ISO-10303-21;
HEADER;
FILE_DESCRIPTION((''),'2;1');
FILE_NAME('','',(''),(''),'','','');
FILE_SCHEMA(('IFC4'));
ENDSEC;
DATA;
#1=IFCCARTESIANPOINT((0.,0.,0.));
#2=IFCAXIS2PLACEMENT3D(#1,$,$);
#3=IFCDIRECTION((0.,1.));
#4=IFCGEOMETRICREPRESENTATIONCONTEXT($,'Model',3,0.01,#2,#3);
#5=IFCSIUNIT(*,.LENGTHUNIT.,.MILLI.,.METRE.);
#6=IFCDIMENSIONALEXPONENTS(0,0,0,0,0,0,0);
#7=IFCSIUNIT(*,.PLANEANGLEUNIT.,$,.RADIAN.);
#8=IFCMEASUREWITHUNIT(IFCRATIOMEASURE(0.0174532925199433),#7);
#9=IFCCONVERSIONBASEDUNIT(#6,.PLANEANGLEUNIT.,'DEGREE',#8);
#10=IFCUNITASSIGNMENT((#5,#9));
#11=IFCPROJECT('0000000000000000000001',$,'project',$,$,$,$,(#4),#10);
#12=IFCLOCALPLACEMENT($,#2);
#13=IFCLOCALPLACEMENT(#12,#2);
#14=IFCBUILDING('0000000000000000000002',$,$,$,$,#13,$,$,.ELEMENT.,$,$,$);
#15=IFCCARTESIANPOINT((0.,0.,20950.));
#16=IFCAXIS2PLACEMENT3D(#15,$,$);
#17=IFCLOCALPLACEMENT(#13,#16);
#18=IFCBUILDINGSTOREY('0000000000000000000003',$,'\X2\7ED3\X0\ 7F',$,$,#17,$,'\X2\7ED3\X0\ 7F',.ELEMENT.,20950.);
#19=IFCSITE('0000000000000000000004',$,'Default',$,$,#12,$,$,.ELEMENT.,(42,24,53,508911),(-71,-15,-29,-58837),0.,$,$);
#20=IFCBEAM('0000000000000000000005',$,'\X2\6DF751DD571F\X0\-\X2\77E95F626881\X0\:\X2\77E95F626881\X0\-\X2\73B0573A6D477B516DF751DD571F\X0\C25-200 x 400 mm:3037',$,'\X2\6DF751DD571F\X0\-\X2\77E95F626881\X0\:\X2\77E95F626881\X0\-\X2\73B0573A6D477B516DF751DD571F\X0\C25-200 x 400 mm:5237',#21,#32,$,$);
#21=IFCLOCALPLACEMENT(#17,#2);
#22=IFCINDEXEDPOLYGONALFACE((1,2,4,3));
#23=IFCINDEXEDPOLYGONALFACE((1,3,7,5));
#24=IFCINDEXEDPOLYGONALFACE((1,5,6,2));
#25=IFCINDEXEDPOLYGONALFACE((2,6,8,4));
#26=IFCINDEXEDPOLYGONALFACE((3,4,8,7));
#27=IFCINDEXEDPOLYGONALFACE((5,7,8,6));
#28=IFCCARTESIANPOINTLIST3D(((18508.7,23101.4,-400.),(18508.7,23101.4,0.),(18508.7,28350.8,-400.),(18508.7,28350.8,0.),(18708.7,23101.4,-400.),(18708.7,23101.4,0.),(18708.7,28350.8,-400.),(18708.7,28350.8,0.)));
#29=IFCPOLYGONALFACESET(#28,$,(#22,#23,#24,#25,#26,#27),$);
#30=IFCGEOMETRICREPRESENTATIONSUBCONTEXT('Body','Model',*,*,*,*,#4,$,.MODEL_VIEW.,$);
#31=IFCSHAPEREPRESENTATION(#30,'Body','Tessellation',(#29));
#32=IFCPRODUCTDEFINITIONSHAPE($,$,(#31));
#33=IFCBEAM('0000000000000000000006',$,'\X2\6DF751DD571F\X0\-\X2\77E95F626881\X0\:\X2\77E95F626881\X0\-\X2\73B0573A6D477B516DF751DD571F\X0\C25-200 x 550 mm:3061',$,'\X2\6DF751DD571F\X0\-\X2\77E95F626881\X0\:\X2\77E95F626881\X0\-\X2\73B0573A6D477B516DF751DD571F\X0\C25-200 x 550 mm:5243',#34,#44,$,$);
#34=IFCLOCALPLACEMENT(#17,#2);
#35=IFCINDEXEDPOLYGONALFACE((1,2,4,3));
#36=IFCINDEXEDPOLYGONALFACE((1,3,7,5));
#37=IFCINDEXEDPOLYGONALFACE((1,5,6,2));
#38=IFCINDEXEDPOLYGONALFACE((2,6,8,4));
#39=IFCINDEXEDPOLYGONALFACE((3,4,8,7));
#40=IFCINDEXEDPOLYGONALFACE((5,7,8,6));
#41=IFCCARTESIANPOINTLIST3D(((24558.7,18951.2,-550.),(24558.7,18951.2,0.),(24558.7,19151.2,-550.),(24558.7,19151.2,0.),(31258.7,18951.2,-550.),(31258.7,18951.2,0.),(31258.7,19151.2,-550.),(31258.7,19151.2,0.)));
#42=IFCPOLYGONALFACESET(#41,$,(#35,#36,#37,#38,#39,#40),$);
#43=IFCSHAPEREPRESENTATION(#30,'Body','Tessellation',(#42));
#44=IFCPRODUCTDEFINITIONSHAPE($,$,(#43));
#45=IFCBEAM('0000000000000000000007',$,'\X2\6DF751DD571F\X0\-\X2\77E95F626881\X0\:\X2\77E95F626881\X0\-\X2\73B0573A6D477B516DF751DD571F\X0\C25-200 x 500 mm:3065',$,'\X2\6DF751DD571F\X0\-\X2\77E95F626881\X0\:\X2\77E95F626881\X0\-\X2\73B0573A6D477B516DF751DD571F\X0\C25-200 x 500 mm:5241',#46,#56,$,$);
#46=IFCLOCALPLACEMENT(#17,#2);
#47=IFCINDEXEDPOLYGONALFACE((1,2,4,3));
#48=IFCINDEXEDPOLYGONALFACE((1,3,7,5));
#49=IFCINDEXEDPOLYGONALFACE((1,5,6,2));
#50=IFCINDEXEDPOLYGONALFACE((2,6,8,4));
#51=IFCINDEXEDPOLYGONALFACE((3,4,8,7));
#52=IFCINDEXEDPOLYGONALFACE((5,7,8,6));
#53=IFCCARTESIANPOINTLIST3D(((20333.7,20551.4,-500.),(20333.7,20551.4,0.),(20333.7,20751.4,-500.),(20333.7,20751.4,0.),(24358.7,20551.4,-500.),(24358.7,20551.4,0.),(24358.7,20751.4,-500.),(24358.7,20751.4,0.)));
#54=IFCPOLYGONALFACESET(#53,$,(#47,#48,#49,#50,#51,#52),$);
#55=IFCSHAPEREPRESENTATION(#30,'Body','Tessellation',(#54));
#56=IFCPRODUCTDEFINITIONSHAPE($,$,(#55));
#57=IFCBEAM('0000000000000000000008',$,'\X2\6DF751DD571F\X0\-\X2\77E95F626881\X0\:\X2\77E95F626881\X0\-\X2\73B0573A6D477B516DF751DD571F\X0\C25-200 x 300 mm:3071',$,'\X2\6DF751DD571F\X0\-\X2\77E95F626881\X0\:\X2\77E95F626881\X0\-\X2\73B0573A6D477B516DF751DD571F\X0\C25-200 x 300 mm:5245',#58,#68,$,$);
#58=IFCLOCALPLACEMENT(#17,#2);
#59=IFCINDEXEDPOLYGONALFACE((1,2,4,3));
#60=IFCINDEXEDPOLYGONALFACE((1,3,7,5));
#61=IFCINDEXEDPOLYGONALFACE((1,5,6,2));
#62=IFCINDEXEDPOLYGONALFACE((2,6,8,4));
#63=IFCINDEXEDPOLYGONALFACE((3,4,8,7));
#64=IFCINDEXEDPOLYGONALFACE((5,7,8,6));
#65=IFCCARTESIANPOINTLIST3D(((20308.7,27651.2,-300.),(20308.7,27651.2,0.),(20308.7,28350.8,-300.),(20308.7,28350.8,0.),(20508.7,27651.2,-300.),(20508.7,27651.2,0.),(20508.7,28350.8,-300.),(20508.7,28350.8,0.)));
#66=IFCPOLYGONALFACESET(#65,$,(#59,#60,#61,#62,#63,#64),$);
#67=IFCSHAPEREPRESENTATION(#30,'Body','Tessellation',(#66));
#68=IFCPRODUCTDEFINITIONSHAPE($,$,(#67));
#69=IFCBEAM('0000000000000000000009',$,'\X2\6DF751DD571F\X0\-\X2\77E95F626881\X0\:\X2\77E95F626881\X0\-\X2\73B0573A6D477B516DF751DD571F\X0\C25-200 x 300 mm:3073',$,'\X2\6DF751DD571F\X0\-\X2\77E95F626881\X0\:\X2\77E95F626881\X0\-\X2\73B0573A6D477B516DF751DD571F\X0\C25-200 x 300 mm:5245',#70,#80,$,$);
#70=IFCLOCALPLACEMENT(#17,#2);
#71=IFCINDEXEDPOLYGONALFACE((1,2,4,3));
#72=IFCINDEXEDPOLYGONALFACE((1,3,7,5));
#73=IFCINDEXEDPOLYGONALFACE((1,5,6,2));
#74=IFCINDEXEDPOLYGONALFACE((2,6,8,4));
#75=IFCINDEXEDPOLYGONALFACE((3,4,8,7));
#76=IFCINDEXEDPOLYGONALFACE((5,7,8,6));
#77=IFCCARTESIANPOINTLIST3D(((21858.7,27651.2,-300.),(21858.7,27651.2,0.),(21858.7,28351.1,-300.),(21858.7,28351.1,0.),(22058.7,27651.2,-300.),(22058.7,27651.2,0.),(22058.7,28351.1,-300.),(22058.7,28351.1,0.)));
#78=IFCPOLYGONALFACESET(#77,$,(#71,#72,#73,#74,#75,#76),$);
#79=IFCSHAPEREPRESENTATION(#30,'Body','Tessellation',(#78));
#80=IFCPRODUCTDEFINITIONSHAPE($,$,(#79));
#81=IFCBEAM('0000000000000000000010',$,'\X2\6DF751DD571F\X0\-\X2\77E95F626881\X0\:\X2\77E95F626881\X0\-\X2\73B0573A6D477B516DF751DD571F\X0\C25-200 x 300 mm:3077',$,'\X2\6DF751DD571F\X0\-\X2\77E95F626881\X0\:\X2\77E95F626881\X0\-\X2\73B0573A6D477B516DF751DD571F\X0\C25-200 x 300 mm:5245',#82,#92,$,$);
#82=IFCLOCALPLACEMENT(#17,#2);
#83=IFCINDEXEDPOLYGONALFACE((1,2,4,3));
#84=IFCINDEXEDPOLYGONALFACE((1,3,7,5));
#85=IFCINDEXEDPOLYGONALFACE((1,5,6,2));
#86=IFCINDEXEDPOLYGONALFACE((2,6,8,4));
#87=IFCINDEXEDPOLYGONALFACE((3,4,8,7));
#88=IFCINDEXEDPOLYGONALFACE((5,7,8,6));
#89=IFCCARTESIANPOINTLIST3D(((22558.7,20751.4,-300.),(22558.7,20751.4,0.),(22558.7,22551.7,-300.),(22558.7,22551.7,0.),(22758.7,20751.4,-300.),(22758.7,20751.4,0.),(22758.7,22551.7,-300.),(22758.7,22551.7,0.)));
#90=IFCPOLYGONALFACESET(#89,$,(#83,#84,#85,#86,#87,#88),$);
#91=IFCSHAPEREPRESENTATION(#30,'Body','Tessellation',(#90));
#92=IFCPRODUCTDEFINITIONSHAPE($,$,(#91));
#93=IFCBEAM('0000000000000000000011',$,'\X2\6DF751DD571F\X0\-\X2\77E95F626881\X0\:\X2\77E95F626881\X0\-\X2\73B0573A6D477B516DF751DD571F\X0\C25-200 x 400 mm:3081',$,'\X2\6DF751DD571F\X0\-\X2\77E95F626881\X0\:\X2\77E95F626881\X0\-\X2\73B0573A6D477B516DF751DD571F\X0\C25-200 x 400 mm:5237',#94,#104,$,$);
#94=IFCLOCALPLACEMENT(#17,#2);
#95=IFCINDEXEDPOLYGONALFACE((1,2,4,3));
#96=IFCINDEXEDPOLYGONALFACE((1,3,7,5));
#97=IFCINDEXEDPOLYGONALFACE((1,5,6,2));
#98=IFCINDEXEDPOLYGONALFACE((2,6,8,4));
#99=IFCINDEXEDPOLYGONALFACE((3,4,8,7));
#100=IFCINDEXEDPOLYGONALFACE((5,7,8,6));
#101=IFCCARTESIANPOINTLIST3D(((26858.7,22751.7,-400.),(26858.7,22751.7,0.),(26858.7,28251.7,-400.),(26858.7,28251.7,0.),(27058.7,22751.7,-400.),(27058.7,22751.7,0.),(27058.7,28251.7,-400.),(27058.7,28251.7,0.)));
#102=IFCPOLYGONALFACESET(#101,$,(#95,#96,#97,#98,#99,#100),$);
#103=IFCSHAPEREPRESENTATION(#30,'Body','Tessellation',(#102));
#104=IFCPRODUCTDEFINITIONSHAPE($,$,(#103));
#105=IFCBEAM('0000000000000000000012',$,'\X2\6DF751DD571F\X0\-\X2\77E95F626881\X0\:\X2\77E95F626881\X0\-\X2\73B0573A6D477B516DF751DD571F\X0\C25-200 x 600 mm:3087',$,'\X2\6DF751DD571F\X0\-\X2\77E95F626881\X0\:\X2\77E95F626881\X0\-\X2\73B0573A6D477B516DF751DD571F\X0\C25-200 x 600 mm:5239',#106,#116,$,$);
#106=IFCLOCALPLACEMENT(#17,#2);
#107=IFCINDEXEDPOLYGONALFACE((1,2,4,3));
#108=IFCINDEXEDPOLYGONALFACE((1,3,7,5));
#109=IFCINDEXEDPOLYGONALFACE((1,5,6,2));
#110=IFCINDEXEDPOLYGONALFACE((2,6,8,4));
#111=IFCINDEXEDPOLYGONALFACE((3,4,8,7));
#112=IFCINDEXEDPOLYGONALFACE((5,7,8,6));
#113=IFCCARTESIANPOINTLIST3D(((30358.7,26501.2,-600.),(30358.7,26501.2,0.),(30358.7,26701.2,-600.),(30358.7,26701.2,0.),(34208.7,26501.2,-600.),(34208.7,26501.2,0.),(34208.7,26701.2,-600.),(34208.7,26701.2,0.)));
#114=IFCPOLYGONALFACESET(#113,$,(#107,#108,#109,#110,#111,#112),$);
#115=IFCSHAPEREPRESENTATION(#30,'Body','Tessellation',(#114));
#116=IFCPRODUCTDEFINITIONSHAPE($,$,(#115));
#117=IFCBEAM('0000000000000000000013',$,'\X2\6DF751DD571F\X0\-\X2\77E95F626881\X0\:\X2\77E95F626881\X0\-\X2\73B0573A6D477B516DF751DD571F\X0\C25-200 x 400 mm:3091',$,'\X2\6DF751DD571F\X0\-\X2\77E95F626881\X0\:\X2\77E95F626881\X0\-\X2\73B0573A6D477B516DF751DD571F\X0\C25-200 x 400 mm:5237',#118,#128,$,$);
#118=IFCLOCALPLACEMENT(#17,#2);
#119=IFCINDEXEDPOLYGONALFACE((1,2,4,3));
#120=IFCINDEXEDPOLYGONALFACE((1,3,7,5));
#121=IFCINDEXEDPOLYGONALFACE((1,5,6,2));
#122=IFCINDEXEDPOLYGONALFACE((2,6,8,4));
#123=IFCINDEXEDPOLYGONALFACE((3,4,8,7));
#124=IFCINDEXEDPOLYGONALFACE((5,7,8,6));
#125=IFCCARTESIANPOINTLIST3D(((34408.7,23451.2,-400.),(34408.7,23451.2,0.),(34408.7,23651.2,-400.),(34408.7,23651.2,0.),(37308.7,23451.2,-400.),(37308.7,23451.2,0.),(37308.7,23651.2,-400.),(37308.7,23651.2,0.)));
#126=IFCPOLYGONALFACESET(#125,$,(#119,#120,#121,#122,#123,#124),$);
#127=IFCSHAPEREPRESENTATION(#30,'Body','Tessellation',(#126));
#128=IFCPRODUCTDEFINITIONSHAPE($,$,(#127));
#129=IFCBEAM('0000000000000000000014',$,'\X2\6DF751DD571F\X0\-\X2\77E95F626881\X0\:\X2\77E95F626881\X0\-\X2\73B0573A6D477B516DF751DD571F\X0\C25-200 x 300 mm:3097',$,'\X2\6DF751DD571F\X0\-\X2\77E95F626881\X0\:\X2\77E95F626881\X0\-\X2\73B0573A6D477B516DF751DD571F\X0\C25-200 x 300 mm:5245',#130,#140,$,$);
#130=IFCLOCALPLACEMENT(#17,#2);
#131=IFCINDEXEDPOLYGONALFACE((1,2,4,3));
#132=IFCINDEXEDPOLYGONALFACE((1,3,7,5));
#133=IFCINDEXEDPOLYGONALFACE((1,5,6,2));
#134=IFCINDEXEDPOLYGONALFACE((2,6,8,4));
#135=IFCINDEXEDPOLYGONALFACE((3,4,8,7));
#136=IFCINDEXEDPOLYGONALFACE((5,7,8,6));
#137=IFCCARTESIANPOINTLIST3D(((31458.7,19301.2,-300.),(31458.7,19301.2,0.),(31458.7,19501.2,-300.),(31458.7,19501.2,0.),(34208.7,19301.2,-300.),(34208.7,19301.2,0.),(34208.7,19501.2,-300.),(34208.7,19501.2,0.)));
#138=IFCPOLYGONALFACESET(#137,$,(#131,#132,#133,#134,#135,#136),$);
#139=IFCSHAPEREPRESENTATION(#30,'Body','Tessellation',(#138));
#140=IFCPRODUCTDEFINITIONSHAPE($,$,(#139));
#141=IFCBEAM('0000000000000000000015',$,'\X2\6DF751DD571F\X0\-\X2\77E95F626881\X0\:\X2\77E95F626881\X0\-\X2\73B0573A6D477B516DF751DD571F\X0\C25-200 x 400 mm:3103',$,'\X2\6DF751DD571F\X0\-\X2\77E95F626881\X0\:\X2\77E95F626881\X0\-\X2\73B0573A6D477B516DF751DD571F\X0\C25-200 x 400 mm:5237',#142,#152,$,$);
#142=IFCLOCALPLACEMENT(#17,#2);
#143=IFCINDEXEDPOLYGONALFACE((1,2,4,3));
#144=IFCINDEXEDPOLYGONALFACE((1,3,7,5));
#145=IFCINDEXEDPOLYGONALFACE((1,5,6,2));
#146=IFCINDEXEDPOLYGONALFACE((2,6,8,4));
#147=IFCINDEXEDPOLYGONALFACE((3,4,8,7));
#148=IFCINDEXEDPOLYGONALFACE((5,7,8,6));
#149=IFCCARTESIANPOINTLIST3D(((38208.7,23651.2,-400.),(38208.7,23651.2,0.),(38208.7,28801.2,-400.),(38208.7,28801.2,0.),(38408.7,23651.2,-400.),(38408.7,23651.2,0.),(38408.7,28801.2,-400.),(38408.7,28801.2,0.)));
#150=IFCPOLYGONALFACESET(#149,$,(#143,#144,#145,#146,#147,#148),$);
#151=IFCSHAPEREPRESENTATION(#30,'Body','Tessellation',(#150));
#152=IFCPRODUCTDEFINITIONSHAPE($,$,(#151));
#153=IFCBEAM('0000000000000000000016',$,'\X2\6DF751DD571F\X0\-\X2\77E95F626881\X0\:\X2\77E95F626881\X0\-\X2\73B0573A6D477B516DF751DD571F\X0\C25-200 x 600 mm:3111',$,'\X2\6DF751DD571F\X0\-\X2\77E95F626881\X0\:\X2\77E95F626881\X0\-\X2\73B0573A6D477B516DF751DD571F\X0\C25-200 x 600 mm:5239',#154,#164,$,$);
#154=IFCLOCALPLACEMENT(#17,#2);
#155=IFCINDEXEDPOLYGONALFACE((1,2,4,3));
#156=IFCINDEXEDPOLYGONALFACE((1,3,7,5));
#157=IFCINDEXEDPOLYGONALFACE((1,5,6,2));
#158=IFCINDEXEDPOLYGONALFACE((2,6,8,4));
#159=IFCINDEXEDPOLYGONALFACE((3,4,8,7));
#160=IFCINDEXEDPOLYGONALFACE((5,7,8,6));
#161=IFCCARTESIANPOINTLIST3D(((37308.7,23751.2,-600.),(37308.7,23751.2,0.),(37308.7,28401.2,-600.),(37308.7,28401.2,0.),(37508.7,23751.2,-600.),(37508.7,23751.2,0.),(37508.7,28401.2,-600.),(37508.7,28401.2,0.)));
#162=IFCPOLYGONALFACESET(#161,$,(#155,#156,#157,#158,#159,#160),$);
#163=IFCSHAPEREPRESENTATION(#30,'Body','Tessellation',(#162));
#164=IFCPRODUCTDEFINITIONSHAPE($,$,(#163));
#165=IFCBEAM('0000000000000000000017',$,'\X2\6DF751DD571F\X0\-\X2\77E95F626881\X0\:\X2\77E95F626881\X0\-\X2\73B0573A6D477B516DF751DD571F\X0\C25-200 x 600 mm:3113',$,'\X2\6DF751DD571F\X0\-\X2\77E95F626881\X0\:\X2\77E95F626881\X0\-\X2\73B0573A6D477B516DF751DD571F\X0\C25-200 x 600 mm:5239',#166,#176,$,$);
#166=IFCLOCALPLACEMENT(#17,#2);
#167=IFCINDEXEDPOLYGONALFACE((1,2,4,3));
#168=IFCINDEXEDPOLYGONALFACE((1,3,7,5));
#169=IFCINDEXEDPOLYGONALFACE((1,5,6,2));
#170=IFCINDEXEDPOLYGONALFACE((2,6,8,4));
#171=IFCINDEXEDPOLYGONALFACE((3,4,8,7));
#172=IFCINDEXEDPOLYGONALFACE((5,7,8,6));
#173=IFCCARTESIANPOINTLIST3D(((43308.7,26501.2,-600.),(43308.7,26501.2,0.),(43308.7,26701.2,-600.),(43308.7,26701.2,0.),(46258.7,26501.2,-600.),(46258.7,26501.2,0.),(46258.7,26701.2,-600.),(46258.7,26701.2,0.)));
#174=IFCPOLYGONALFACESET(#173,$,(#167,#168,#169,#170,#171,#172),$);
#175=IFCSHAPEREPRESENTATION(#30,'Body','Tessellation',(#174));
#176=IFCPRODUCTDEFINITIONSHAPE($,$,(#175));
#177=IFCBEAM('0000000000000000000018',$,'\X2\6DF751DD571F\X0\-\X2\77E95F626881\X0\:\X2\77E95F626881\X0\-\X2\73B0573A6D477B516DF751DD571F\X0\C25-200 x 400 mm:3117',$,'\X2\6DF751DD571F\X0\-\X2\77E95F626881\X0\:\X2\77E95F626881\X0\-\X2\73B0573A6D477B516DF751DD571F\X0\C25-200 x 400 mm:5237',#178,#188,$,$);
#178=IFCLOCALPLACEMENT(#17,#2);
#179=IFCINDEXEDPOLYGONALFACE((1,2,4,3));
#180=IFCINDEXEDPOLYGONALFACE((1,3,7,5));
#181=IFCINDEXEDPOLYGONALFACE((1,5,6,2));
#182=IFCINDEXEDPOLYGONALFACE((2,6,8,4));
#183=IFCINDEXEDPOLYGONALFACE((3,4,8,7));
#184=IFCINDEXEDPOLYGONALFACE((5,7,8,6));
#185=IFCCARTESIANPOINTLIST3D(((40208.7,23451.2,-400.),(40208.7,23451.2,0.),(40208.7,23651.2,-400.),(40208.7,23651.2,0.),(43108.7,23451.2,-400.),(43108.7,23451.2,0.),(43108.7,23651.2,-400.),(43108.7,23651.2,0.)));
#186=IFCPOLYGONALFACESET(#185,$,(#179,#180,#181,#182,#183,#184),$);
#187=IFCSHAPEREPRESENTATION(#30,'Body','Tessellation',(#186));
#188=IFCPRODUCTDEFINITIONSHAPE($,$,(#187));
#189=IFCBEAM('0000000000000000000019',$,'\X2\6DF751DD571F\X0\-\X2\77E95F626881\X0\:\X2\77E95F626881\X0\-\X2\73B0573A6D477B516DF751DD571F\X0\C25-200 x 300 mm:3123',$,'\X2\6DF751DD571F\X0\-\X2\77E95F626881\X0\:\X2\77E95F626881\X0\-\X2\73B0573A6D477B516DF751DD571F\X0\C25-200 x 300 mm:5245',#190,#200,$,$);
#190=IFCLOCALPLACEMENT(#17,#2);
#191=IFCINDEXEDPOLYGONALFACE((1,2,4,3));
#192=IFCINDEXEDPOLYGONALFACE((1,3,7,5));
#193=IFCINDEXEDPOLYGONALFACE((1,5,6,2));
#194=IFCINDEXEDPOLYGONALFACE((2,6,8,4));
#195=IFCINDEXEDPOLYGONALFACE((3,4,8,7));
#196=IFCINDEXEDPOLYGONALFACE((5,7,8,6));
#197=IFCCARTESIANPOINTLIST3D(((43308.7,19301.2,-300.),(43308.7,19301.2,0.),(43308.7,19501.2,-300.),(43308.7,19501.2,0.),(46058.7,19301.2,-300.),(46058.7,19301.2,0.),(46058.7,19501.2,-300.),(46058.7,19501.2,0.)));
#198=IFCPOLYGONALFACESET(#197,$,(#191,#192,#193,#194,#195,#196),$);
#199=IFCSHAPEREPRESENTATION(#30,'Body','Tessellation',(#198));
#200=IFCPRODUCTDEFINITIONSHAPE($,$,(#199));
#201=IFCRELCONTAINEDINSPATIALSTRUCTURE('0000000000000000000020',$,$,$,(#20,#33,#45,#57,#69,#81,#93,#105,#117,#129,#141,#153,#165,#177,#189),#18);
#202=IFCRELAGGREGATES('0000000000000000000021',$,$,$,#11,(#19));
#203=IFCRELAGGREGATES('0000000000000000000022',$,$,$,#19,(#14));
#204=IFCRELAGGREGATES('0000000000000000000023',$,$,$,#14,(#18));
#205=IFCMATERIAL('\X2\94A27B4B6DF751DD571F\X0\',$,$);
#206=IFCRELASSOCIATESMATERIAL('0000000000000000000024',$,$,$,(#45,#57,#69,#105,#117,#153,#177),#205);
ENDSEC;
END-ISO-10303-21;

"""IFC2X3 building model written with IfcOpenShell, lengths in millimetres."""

from ifc_helpers import new_model, entity, si_unit, converted_unit, direction, frame, frame_2d, origin, origin_2d_with_axis, place, context, subcontext, project, spatial, rectangle, extrude, material, element, save


model = new_model("IFC2X3")

# Units and contexts
model_context = context("Model", 3, precision=0.01, world=origin(), true_north=direction((0.0, 1.0)))
body_context = subcontext(model_context, "Body", "Model", "MODEL_VIEW")
ifc_project = project(units=[si_unit("LENGTHUNIT", "METRE", prefix="MILLI"), converted_unit("PLANEANGLEUNIT", "DEGREE", entity("IfcRatioMeasure", 0.0174532925199433), si_unit("PLANEANGLEUNIT", "RADIAN"), dimensions=[0, 0, 0, 0, 0, 0, 0])], contexts=[model_context])

# Site, building, storey
site_placement = place(None, origin())
site = spatial("IfcSite", under=ifc_project, at=site_placement, Name="Default", CompositionType="ELEMENT", RefLatitude=(42, 24, 53, 508911), RefLongitude=(-71, -15, -29, -58837), RefElevation=0.0)
building_placement = place(site_placement, origin())
building = spatial("IfcBuilding", under=site, at=building_placement, CompositionType="ELEMENT")
storey_placement = place(building_placement, frame((0.0, 0.0, 20950.0)))
storey = spatial("IfcBuildingStorey", under=building, at=storey_placement, Name="结 7F", LongName="结 7F", CompositionType="ELEMENT", Elevation=20950.0)

# Beams
beam_1_placement = place(storey_placement, frame((18608.7, 23001.4, 0.0), z_axis=(0.0, 0.0, 1.0), x_axis=(0.0, 1.0, 0.0)))
element("IfcBeam", 1, at=beam_1_placement, inside=storey, Name="混凝土-矩形梁:矩形梁-现场浇筑混凝土C25-200 x 400 mm:3037", ObjectType="混凝土-矩形梁:矩形梁-现场浇筑混凝土C25-200 x 400 mm:5237", context=body_context, shape_type="SweptSolid", body=[
    extrude(rectangle(XDim=400.0, YDim=200.0, at=frame_2d((0.0, 0.0), x_axis=(1.0, 0.0))), frame((100.0, 0.0, -200.0), z_axis=(1.0, 0.0, 0.0), x_axis=(0.0, 0.0, -1.0)), (0.0, 0.0, 1.0), 5249.4),
])
ifc_material = material(Name="钢筋混凝土")
beam_2_placement = place(storey_placement, frame((31358.7, 19051.2, 0.0), z_axis=(0.0, 0.0, 1.0), x_axis=(-1.0, 0.0, 0.0)))
element("IfcBeam", 2, at=beam_2_placement, inside=storey, Name="混凝土-矩形梁:矩形梁-现场浇筑混凝土C25-200 x 550 mm:3061", ObjectType="混凝土-矩形梁:矩形梁-现场浇筑混凝土C25-200 x 550 mm:5243", context=body_context, shape_type="SweptSolid", body=[
    extrude(rectangle(XDim=550.0, YDim=200.0, at=frame_2d((0.0, 0.0), x_axis=(1.0, 0.0))), frame((100.0, 0.0, -275.0), z_axis=(1.0, 0.0, 0.0), x_axis=(0.0, 0.0, -1.0)), (0.0, 0.0, 1.0), 6700.0),
])
beam_3_placement = place(storey_placement, frame((24458.7, 20651.4, 0.0), z_axis=(0.0, 0.0, 1.0), x_axis=(-1.0, 0.0, 0.0)))
element("IfcBeam", 3, at=beam_3_placement, inside=storey, material=ifc_material, Name="混凝土-矩形梁:矩形梁-现场浇筑混凝土C25-200 x 500 mm:3065", ObjectType="混凝土-矩形梁:矩形梁-现场浇筑混凝土C25-200 x 500 mm:5241", context=body_context, shape_type="SweptSolid", body=[
    extrude(rectangle(XDim=500.0, YDim=200.0, at=frame_2d((0.0, 0.0), x_axis=(1.0, 0.0))), frame((100.0, 0.0, -250.0), z_axis=(1.0, 0.0, 0.0), x_axis=(0.0, 0.0, -1.0)), (0.0, 0.0, 1.0), 4025.0),
])
beam_4_placement = place(storey_placement, frame((20408.7, 27551.2, 0.0), z_axis=(0.0, 0.0, 1.0), x_axis=(0.0, 1.0, 0.0)))
element("IfcBeam", 4, at=beam_4_placement, inside=storey, material=ifc_material, Name="混凝土-矩形梁:矩形梁-现场浇筑混凝土C25-200 x 300 mm:3071", ObjectType="混凝土-矩形梁:矩形梁-现场浇筑混凝土C25-200 x 300 mm:5245", context=body_context, shape_type="SweptSolid", body=[
    extrude(rectangle(XDim=300.0, YDim=200.0, at=frame_2d((0.0, 0.0), x_axis=(1.0, 0.0))), frame((100.0, 0.0, -150.0), z_axis=(1.0, 0.0, 0.0), x_axis=(0.0, 0.0, -1.0)), (0.0, 0.0, 1.0), 699.6),
])
beam_5_placement = place(storey_placement, frame((21958.7, 27551.2, 0.0), z_axis=(0.0, 0.0, 1.0), x_axis=(0.0, 1.0, 0.0)))
element("IfcBeam", 5, at=beam_5_placement, inside=storey, material=ifc_material, Name="混凝土-矩形梁:矩形梁-现场浇筑混凝土C25-200 x 300 mm:3073", ObjectType="混凝土-矩形梁:矩形梁-现场浇筑混凝土C25-200 x 300 mm:5245", context=body_context, shape_type="SweptSolid", body=[
    extrude(rectangle(XDim=300.0, YDim=200.0, at=frame_2d((0.0, 0.0), x_axis=(1.0, 0.0))), frame((100.0, 0.0, -150.0), z_axis=(1.0, 0.0, 0.0), x_axis=(0.0, 0.0, -1.0)), (0.0, 0.0, 1.0), 699.9),
])
beam_6_placement = place(storey_placement, frame((22658.7, 20651.4, 0.0), z_axis=(0.0, 0.0, 1.0), x_axis=(0.0, 1.0, 0.0)))
element("IfcBeam", 6, at=beam_6_placement, inside=storey, Name="混凝土-矩形梁:矩形梁-现场浇筑混凝土C25-200 x 300 mm:3077", ObjectType="混凝土-矩形梁:矩形梁-现场浇筑混凝土C25-200 x 300 mm:5245", context=body_context, shape_type="SweptSolid", body=[
    extrude(rectangle(XDim=300.0, YDim=200.0, at=origin_2d_with_axis()), frame((100.0, 0.0, -150.0), z_axis=(1.0, 0.0, 0.0), x_axis=(0.0, 0.0, -1.0)), (0.0, 0.0, 1.0), 1800.3),
])
beam_7_placement = place(storey_placement, frame((26958.7, 22651.7, 0.0), z_axis=(0.0, 0.0, 1.0), x_axis=(0.0, 1.0, 0.0)))
element("IfcBeam", 7, at=beam_7_placement, inside=storey, Name="混凝土-矩形梁:矩形梁-现场浇筑混凝土C25-200 x 400 mm:3081", ObjectType="混凝土-矩形梁:矩形梁-现场浇筑混凝土C25-200 x 400 mm:5237", context=body_context, shape_type="SweptSolid", body=[
    extrude(rectangle(XDim=400.0, YDim=200.0, at=frame_2d((0.0, 0.0), x_axis=(1.0, 0.0))), frame((100.0, 0.0, -200.0), z_axis=(1.0, 0.0, 0.0), x_axis=(0.0, 0.0, -1.0)), (0.0, 0.0, 1.0), 5500.0),
])
beam_8_placement = place(storey_placement, frame((34308.7, 26601.2, 0.0), z_axis=(0.0, 0.0, 1.0), x_axis=(-1.0, 0.0, 0.0)))
element("IfcBeam", 8, at=beam_8_placement, inside=storey, material=ifc_material, Name="混凝土-矩形梁:矩形梁-现场浇筑混凝土C25-200 x 600 mm:3087", ObjectType="混凝土-矩形梁:矩形梁-现场浇筑混凝土C25-200 x 600 mm:5239", context=body_context, shape_type="SweptSolid", body=[
    extrude(rectangle(XDim=600.0, YDim=200.0, at=frame_2d((0.0, 0.0), x_axis=(1.0, 0.0))), frame((100.0, 0.0, -300.0), z_axis=(1.0, 0.0, 0.0), x_axis=(0.0, 0.0, -1.0)), (0.0, 0.0, 1.0), 3850.0),
])
beam_9_placement = place(storey_placement, frame((34308.7, 23551.2, 0.0)))
element("IfcBeam", 9, at=beam_9_placement, inside=storey, material=ifc_material, Name="混凝土-矩形梁:矩形梁-现场浇筑混凝土C25-200 x 400 mm:3091", ObjectType="混凝土-矩形梁:矩形梁-现场浇筑混凝土C25-200 x 400 mm:5237", context=body_context, shape_type="SweptSolid", body=[
    extrude(rectangle(XDim=400.0, YDim=200.0, at=frame_2d((0.0, 0.0), x_axis=(1.0, 0.0))), frame((100.0, 0.0, -200.0), z_axis=(1.0, 0.0, 0.0), x_axis=(0.0, 0.0, -1.0)), (0.0, 0.0, 1.0), 2900.0),
])
beam_10_placement = place(storey_placement, frame((31358.7, 19401.2, 0.0)))
element("IfcBeam", 10, at=beam_10_placement, inside=storey, Name="混凝土-矩形梁:矩形梁-现场浇筑混凝土C25-200 x 300 mm:3097", ObjectType="混凝土-矩形梁:矩形梁-现场浇筑混凝土C25-200 x 300 mm:5245", context=body_context, shape_type="SweptSolid", body=[
    extrude(rectangle(XDim=300.0, YDim=200.0, at=frame_2d((0.0, 0.0), x_axis=(1.0, 0.0))), frame((100.0, 0.0, -150.0), z_axis=(1.0, 0.0, 0.0), x_axis=(0.0, 0.0, -1.0)), (0.0, 0.0, 1.0), 2750.0),
])
beam_11_placement = place(storey_placement, frame((38308.7, 23551.2, 0.0), z_axis=(0.0, 0.0, 1.0), x_axis=(0.0, 1.0, 0.0)))
element("IfcBeam", 11, at=beam_11_placement, inside=storey, Name="混凝土-矩形梁:矩形梁-现场浇筑混凝土C25-200 x 400 mm:3103", ObjectType="混凝土-矩形梁:矩形梁-现场浇筑混凝土C25-200 x 400 mm:5237", context=body_context, shape_type="SweptSolid", body=[
    extrude(rectangle(XDim=400.0, YDim=200.0, at=frame_2d((0.0, 0.0), x_axis=(1.0, 0.0))), frame((100.0, 0.0, -200.0), z_axis=(1.0, 0.0, 0.0), x_axis=(0.0, 0.0, -1.0)), (0.0, 0.0, 1.0), 5150.0),
])
beam_12_placement = place(storey_placement, frame((37408.7, 23551.2, 0.0), z_axis=(0.0, 0.0, 1.0), x_axis=(0.0, 1.0, 0.0)))
element("IfcBeam", 12, at=beam_12_placement, inside=storey, material=ifc_material, Name="混凝土-矩形梁:矩形梁-现场浇筑混凝土C25-200 x 600 mm:3111", ObjectType="混凝土-矩形梁:矩形梁-现场浇筑混凝土C25-200 x 600 mm:5239", context=body_context, shape_type="SweptSolid", body=[
    extrude(rectangle(XDim=600.0, YDim=200.0, at=frame_2d((0.0, 0.0), x_axis=(1.0, 0.0))), frame((200.0, 0.0, -300.0), z_axis=(1.0, 0.0, 0.0), x_axis=(0.0, 0.0, -1.0)), (0.0, 0.0, 1.0), 4650.0),
])
beam_13_placement = place(storey_placement, frame((43208.7, 26601.2, 0.0)))
element("IfcBeam", 13, at=beam_13_placement, inside=storey, Name="混凝土-矩形梁:矩形梁-现场浇筑混凝土C25-200 x 600 mm:3113", ObjectType="混凝土-矩形梁:矩形梁-现场浇筑混凝土C25-200 x 600 mm:5239", context=body_context, shape_type="SweptSolid", body=[
    extrude(rectangle(XDim=600.0, YDim=200.0, at=frame_2d((0.0, 0.0), x_axis=(1.0, 0.0))), frame((100.0, 0.0, -300.0), z_axis=(1.0, 0.0, 0.0), x_axis=(0.0, 0.0, -1.0)), (0.0, 0.0, 1.0), 2950.0),
])
beam_14_placement = place(storey_placement, frame((43208.7, 23551.2, 0.0), z_axis=(0.0, 0.0, 1.0), x_axis=(-1.0, 0.0, 0.0)))
element("IfcBeam", 14, at=beam_14_placement, inside=storey, material=ifc_material, Name="混凝土-矩形梁:矩形梁-现场浇筑混凝土C25-200 x 400 mm:3117", ObjectType="混凝土-矩形梁:矩形梁-现场浇筑混凝土C25-200 x 400 mm:5237", context=body_context, shape_type="SweptSolid", body=[
    extrude(rectangle(XDim=400.0, YDim=200.0, at=frame_2d((0.0, 0.0), x_axis=(1.0, 0.0))), frame((100.0, 0.0, -200.0), z_axis=(1.0, 0.0, 0.0), x_axis=(0.0, 0.0, -1.0)), (0.0, 0.0, 1.0), 2900.0),
])
beam_15_placement = place(storey_placement, frame((46158.7, 19401.2, 0.0), z_axis=(0.0, 0.0, 1.0), x_axis=(-1.0, 0.0, 0.0)))
element("IfcBeam", 15, at=beam_15_placement, inside=storey, Name="混凝土-矩形梁:矩形梁-现场浇筑混凝土C25-200 x 300 mm:3123", ObjectType="混凝土-矩形梁:矩形梁-现场浇筑混凝土C25-200 x 300 mm:5245", context=body_context, shape_type="SweptSolid", body=[
    extrude(rectangle(XDim=300.0, YDim=200.0, at=frame_2d((0.0, 0.0), x_axis=(1.0, 0.0))), frame((100.0, 0.0, -150.0), z_axis=(1.0, 0.0, 0.0), x_axis=(0.0, 0.0, -1.0)), (0.0, 0.0, 1.0), 2750.0),
])

save(model, "model.ifc")
